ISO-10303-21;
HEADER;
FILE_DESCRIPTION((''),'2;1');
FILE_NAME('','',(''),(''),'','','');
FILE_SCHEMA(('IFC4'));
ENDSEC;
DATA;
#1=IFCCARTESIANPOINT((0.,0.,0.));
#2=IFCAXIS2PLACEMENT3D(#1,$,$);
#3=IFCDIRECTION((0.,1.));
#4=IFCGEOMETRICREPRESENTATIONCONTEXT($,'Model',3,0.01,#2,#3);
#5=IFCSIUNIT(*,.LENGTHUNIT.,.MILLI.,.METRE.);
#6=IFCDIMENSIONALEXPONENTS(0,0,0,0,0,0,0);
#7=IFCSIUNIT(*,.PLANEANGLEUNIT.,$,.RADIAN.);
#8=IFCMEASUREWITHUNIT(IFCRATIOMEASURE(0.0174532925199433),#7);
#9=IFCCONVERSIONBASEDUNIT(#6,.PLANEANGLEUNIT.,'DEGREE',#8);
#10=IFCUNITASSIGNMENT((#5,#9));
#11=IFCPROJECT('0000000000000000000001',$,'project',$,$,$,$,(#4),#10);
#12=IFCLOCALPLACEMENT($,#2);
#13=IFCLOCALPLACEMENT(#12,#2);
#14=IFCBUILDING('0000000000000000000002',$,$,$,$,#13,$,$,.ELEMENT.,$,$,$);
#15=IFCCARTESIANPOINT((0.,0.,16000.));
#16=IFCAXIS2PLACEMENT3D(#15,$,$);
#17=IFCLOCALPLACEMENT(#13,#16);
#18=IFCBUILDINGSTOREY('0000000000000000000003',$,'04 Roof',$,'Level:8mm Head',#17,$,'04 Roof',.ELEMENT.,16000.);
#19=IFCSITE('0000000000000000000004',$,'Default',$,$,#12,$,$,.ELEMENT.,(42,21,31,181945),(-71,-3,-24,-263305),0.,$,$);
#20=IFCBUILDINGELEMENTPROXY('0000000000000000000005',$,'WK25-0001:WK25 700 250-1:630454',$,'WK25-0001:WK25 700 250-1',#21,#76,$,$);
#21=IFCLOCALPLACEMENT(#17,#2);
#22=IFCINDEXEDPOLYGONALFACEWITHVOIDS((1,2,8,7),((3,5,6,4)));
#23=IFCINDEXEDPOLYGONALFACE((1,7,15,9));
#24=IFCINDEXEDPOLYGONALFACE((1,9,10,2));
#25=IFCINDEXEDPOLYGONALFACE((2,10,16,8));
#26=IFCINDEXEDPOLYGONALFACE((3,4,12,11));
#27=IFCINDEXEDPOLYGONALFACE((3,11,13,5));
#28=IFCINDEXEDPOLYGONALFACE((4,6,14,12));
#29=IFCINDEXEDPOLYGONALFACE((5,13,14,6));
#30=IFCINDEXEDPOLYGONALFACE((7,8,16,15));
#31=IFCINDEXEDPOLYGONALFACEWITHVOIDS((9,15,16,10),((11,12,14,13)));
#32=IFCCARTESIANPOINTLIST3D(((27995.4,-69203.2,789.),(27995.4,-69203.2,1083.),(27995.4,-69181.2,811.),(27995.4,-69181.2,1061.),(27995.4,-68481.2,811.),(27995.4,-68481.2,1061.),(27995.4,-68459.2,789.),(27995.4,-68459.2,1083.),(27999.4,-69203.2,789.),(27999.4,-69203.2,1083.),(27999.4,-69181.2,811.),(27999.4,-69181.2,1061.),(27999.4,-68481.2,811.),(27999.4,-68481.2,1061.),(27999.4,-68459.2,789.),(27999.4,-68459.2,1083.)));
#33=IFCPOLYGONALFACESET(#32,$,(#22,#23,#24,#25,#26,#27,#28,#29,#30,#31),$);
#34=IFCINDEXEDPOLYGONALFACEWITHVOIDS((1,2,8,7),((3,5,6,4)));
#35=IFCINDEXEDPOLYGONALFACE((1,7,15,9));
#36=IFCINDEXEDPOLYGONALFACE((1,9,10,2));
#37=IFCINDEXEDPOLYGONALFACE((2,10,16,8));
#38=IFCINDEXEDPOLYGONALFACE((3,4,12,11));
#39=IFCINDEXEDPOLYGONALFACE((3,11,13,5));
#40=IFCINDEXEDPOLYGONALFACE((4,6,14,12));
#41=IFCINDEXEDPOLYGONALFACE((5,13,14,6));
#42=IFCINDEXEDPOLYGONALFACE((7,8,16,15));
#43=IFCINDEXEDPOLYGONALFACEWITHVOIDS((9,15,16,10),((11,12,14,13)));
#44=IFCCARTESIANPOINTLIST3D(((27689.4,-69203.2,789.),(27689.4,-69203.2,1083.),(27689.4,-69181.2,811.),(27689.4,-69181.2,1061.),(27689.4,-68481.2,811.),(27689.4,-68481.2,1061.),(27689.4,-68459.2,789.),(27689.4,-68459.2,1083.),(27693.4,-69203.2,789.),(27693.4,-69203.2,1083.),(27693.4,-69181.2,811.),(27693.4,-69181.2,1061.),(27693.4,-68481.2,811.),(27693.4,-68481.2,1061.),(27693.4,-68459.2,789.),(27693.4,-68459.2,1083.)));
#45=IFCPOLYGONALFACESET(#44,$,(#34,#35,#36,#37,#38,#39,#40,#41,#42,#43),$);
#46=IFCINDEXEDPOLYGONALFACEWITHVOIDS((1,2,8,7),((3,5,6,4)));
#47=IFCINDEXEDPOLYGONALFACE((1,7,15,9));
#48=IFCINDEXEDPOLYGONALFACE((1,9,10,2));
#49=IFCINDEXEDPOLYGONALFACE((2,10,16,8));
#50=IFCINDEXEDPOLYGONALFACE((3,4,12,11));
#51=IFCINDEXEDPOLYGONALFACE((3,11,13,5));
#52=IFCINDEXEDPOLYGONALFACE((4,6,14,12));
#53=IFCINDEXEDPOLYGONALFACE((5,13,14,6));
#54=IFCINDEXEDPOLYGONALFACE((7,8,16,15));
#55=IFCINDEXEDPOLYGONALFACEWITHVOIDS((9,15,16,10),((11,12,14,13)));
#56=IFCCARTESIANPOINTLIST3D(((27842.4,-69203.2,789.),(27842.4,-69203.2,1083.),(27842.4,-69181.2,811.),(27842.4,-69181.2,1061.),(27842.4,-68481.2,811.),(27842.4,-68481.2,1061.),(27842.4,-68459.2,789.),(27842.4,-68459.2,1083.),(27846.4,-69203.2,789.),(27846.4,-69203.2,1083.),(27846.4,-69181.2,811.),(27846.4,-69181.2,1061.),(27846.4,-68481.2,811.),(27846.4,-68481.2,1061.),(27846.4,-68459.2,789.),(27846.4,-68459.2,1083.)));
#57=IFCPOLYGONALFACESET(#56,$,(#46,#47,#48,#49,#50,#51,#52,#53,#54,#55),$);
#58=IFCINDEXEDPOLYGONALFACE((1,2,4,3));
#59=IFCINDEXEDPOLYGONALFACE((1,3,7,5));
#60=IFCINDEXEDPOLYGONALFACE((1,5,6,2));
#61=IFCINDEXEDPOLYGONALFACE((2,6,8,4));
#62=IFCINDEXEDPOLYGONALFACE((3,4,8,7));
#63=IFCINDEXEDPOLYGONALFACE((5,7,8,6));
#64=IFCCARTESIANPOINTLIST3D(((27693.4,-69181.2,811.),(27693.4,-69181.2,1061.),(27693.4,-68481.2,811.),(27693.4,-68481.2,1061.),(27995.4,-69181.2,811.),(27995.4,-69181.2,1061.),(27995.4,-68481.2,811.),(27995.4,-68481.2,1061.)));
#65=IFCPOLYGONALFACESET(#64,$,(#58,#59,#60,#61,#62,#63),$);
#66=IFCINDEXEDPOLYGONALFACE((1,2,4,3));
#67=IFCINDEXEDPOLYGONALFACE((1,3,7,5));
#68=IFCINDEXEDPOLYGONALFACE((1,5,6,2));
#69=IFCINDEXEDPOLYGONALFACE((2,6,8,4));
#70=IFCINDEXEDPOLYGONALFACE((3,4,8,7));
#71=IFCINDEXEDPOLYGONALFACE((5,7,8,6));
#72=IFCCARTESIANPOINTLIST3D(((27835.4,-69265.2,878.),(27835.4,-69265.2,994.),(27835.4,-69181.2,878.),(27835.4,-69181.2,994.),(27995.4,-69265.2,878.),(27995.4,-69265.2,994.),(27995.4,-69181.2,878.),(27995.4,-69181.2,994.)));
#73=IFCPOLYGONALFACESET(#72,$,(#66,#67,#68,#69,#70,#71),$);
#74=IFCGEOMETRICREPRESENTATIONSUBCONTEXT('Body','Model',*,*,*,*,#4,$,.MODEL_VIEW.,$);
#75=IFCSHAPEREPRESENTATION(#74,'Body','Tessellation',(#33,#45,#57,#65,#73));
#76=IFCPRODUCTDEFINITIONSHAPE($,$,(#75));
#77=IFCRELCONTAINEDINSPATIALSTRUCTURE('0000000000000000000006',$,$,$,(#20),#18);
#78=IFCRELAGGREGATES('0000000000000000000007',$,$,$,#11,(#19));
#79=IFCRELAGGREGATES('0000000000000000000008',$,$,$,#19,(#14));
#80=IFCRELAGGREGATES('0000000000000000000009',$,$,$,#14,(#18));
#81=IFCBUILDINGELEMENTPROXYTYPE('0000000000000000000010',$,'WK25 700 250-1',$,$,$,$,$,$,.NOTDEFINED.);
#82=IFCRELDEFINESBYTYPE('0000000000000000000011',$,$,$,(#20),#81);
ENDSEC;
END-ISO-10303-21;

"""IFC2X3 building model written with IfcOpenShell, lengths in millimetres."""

from ifc_helpers import new_model, entity, si_unit, converted_unit, direction, frame, origin, origin_2d_with_axis, place, context, subcontext, project, spatial, polyline, rectangle, outline, extrude, source, transform, mapped, type_object, type_shapes, element, save


model = new_model("IFC2X3")

# Units and contexts
model_context = context("Model", 3, precision=0.01, world=origin(), true_north=direction((0.0, 1.0)))
body_context = subcontext(model_context, "Body", "Model", "MODEL_VIEW")
ifc_project = project(units=[si_unit("LENGTHUNIT", "METRE", prefix="MILLI"), converted_unit("PLANEANGLEUNIT", "DEGREE", entity("IfcRatioMeasure", 0.0174532925199433), si_unit("PLANEANGLEUNIT", "RADIAN"), dimensions=[0, 0, 0, 0, 0, 0, 0])], contexts=[model_context])

# Site, building, storey
site_placement = place(None, origin())
site = spatial("IfcSite", under=ifc_project, at=site_placement, Name="Default", CompositionType="ELEMENT", RefLatitude=(42, 21, 31, 181945), RefLongitude=(-71, -3, -24, -263305), RefElevation=0.0)
building_placement = place(site_placement, origin())
building = spatial("IfcBuilding", under=site, at=building_placement, CompositionType="ELEMENT")
storey_placement = place(building_placement, frame((0.0, 0.0, 16000.0)))
storey = spatial("IfcBuildingStorey", under=building, at=storey_placement, Name="04 Roof", ObjectType="Level:8mm Head", LongName="04 Roof", CompositionType="ELEMENT", Elevation=16000.0)

# Building element proxy
building_element_proxy_type = type_object("IfcBuildingElementProxyType", Name="WK25 700 250-1", PredefinedType="NOTDEFINED")
shared_shape_1 = source(origin(), body_context, "Body", "SweptSolid", [
    extrude(outline(polyline([(-147.0, -372.0), (147.0, -372.0), (147.0, 372.0), (-147.0, 372.0), (-147.0, -372.0)]), holes=[polyline([(-125.0, -350.0), (-125.0, 350.0), (125.0, 350.0), (125.0, -350.0), (-125.0, -350.0)])]), frame((151.0, 0.0, 0.0), z_axis=(1.0, 0.0, 0.0), x_axis=(0.0, 0.0, -1.0)), (0.0, 0.0, 1.0), 4.0),
    extrude(outline(polyline([(-372.0, -147.0), (372.0, -147.0), (372.0, 147.0), (-372.0, 147.0), (-372.0, -147.0)]), holes=[polyline([(-350.0, -125.0), (-350.0, 125.0), (350.0, 125.0), (350.0, -125.0), (-350.0, -125.0)])]), frame((-155.0, 0.0, 0.0), z_axis=(1.0, 0.0, 0.0), x_axis=(0.0, -1.0, 0.0)), (0.0, 0.0, 1.0), 4.0),
    extrude(outline(polyline([(-372.0, -147.0), (372.0, -147.0), (372.0, 147.0), (-372.0, 147.0), (-372.0, -147.0)]), holes=[polyline([(-350.0, -125.0), (-350.0, 125.0), (350.0, 125.0), (350.0, -125.0), (-350.0, -125.0)])]), frame((-2.0, 0.0, 0.0), z_axis=(1.0, 0.0, 0.0), x_axis=(0.0, -1.0, 0.0)), (0.0, 0.0, 1.0), 4.0),
    extrude(rectangle(XDim=302.0, YDim=700.0, at=origin_2d_with_axis()), frame((0.0, 0.0, -125.0), z_axis=(0.0, 0.0, 1.0), x_axis=(-1.0, 0.0, 0.0)), (0.0, 0.0, 1.0), 250.0),
    extrude(rectangle(XDim=84.0, YDim=160.0, at=origin_2d_with_axis()), frame((71.0, -392.0, -58.0), z_axis=(0.0, 0.0, 1.0), x_axis=(0.0, -1.0, 0.0)), (0.0, 0.0, 1.0), 116.0),
])
type_shapes(building_element_proxy_type, [shared_shape_1])
proxy_placement = place(storey_placement, frame((27844.4, -68831.2, 936.0)))
element("IfcBuildingElementProxy", 1, at=proxy_placement, inside=storey, type_object=building_element_proxy_type, Name="WK25-0001:WK25 700 250-1:630454", ObjectType="WK25-0001:WK25 700 250-1", context=body_context, shape_type="MappedRepresentation", body=[
    mapped(shared_shape_1, transform((0.0, 0.0, 0.0), scale=1.0)),
])

save(model, "model.ifc")
